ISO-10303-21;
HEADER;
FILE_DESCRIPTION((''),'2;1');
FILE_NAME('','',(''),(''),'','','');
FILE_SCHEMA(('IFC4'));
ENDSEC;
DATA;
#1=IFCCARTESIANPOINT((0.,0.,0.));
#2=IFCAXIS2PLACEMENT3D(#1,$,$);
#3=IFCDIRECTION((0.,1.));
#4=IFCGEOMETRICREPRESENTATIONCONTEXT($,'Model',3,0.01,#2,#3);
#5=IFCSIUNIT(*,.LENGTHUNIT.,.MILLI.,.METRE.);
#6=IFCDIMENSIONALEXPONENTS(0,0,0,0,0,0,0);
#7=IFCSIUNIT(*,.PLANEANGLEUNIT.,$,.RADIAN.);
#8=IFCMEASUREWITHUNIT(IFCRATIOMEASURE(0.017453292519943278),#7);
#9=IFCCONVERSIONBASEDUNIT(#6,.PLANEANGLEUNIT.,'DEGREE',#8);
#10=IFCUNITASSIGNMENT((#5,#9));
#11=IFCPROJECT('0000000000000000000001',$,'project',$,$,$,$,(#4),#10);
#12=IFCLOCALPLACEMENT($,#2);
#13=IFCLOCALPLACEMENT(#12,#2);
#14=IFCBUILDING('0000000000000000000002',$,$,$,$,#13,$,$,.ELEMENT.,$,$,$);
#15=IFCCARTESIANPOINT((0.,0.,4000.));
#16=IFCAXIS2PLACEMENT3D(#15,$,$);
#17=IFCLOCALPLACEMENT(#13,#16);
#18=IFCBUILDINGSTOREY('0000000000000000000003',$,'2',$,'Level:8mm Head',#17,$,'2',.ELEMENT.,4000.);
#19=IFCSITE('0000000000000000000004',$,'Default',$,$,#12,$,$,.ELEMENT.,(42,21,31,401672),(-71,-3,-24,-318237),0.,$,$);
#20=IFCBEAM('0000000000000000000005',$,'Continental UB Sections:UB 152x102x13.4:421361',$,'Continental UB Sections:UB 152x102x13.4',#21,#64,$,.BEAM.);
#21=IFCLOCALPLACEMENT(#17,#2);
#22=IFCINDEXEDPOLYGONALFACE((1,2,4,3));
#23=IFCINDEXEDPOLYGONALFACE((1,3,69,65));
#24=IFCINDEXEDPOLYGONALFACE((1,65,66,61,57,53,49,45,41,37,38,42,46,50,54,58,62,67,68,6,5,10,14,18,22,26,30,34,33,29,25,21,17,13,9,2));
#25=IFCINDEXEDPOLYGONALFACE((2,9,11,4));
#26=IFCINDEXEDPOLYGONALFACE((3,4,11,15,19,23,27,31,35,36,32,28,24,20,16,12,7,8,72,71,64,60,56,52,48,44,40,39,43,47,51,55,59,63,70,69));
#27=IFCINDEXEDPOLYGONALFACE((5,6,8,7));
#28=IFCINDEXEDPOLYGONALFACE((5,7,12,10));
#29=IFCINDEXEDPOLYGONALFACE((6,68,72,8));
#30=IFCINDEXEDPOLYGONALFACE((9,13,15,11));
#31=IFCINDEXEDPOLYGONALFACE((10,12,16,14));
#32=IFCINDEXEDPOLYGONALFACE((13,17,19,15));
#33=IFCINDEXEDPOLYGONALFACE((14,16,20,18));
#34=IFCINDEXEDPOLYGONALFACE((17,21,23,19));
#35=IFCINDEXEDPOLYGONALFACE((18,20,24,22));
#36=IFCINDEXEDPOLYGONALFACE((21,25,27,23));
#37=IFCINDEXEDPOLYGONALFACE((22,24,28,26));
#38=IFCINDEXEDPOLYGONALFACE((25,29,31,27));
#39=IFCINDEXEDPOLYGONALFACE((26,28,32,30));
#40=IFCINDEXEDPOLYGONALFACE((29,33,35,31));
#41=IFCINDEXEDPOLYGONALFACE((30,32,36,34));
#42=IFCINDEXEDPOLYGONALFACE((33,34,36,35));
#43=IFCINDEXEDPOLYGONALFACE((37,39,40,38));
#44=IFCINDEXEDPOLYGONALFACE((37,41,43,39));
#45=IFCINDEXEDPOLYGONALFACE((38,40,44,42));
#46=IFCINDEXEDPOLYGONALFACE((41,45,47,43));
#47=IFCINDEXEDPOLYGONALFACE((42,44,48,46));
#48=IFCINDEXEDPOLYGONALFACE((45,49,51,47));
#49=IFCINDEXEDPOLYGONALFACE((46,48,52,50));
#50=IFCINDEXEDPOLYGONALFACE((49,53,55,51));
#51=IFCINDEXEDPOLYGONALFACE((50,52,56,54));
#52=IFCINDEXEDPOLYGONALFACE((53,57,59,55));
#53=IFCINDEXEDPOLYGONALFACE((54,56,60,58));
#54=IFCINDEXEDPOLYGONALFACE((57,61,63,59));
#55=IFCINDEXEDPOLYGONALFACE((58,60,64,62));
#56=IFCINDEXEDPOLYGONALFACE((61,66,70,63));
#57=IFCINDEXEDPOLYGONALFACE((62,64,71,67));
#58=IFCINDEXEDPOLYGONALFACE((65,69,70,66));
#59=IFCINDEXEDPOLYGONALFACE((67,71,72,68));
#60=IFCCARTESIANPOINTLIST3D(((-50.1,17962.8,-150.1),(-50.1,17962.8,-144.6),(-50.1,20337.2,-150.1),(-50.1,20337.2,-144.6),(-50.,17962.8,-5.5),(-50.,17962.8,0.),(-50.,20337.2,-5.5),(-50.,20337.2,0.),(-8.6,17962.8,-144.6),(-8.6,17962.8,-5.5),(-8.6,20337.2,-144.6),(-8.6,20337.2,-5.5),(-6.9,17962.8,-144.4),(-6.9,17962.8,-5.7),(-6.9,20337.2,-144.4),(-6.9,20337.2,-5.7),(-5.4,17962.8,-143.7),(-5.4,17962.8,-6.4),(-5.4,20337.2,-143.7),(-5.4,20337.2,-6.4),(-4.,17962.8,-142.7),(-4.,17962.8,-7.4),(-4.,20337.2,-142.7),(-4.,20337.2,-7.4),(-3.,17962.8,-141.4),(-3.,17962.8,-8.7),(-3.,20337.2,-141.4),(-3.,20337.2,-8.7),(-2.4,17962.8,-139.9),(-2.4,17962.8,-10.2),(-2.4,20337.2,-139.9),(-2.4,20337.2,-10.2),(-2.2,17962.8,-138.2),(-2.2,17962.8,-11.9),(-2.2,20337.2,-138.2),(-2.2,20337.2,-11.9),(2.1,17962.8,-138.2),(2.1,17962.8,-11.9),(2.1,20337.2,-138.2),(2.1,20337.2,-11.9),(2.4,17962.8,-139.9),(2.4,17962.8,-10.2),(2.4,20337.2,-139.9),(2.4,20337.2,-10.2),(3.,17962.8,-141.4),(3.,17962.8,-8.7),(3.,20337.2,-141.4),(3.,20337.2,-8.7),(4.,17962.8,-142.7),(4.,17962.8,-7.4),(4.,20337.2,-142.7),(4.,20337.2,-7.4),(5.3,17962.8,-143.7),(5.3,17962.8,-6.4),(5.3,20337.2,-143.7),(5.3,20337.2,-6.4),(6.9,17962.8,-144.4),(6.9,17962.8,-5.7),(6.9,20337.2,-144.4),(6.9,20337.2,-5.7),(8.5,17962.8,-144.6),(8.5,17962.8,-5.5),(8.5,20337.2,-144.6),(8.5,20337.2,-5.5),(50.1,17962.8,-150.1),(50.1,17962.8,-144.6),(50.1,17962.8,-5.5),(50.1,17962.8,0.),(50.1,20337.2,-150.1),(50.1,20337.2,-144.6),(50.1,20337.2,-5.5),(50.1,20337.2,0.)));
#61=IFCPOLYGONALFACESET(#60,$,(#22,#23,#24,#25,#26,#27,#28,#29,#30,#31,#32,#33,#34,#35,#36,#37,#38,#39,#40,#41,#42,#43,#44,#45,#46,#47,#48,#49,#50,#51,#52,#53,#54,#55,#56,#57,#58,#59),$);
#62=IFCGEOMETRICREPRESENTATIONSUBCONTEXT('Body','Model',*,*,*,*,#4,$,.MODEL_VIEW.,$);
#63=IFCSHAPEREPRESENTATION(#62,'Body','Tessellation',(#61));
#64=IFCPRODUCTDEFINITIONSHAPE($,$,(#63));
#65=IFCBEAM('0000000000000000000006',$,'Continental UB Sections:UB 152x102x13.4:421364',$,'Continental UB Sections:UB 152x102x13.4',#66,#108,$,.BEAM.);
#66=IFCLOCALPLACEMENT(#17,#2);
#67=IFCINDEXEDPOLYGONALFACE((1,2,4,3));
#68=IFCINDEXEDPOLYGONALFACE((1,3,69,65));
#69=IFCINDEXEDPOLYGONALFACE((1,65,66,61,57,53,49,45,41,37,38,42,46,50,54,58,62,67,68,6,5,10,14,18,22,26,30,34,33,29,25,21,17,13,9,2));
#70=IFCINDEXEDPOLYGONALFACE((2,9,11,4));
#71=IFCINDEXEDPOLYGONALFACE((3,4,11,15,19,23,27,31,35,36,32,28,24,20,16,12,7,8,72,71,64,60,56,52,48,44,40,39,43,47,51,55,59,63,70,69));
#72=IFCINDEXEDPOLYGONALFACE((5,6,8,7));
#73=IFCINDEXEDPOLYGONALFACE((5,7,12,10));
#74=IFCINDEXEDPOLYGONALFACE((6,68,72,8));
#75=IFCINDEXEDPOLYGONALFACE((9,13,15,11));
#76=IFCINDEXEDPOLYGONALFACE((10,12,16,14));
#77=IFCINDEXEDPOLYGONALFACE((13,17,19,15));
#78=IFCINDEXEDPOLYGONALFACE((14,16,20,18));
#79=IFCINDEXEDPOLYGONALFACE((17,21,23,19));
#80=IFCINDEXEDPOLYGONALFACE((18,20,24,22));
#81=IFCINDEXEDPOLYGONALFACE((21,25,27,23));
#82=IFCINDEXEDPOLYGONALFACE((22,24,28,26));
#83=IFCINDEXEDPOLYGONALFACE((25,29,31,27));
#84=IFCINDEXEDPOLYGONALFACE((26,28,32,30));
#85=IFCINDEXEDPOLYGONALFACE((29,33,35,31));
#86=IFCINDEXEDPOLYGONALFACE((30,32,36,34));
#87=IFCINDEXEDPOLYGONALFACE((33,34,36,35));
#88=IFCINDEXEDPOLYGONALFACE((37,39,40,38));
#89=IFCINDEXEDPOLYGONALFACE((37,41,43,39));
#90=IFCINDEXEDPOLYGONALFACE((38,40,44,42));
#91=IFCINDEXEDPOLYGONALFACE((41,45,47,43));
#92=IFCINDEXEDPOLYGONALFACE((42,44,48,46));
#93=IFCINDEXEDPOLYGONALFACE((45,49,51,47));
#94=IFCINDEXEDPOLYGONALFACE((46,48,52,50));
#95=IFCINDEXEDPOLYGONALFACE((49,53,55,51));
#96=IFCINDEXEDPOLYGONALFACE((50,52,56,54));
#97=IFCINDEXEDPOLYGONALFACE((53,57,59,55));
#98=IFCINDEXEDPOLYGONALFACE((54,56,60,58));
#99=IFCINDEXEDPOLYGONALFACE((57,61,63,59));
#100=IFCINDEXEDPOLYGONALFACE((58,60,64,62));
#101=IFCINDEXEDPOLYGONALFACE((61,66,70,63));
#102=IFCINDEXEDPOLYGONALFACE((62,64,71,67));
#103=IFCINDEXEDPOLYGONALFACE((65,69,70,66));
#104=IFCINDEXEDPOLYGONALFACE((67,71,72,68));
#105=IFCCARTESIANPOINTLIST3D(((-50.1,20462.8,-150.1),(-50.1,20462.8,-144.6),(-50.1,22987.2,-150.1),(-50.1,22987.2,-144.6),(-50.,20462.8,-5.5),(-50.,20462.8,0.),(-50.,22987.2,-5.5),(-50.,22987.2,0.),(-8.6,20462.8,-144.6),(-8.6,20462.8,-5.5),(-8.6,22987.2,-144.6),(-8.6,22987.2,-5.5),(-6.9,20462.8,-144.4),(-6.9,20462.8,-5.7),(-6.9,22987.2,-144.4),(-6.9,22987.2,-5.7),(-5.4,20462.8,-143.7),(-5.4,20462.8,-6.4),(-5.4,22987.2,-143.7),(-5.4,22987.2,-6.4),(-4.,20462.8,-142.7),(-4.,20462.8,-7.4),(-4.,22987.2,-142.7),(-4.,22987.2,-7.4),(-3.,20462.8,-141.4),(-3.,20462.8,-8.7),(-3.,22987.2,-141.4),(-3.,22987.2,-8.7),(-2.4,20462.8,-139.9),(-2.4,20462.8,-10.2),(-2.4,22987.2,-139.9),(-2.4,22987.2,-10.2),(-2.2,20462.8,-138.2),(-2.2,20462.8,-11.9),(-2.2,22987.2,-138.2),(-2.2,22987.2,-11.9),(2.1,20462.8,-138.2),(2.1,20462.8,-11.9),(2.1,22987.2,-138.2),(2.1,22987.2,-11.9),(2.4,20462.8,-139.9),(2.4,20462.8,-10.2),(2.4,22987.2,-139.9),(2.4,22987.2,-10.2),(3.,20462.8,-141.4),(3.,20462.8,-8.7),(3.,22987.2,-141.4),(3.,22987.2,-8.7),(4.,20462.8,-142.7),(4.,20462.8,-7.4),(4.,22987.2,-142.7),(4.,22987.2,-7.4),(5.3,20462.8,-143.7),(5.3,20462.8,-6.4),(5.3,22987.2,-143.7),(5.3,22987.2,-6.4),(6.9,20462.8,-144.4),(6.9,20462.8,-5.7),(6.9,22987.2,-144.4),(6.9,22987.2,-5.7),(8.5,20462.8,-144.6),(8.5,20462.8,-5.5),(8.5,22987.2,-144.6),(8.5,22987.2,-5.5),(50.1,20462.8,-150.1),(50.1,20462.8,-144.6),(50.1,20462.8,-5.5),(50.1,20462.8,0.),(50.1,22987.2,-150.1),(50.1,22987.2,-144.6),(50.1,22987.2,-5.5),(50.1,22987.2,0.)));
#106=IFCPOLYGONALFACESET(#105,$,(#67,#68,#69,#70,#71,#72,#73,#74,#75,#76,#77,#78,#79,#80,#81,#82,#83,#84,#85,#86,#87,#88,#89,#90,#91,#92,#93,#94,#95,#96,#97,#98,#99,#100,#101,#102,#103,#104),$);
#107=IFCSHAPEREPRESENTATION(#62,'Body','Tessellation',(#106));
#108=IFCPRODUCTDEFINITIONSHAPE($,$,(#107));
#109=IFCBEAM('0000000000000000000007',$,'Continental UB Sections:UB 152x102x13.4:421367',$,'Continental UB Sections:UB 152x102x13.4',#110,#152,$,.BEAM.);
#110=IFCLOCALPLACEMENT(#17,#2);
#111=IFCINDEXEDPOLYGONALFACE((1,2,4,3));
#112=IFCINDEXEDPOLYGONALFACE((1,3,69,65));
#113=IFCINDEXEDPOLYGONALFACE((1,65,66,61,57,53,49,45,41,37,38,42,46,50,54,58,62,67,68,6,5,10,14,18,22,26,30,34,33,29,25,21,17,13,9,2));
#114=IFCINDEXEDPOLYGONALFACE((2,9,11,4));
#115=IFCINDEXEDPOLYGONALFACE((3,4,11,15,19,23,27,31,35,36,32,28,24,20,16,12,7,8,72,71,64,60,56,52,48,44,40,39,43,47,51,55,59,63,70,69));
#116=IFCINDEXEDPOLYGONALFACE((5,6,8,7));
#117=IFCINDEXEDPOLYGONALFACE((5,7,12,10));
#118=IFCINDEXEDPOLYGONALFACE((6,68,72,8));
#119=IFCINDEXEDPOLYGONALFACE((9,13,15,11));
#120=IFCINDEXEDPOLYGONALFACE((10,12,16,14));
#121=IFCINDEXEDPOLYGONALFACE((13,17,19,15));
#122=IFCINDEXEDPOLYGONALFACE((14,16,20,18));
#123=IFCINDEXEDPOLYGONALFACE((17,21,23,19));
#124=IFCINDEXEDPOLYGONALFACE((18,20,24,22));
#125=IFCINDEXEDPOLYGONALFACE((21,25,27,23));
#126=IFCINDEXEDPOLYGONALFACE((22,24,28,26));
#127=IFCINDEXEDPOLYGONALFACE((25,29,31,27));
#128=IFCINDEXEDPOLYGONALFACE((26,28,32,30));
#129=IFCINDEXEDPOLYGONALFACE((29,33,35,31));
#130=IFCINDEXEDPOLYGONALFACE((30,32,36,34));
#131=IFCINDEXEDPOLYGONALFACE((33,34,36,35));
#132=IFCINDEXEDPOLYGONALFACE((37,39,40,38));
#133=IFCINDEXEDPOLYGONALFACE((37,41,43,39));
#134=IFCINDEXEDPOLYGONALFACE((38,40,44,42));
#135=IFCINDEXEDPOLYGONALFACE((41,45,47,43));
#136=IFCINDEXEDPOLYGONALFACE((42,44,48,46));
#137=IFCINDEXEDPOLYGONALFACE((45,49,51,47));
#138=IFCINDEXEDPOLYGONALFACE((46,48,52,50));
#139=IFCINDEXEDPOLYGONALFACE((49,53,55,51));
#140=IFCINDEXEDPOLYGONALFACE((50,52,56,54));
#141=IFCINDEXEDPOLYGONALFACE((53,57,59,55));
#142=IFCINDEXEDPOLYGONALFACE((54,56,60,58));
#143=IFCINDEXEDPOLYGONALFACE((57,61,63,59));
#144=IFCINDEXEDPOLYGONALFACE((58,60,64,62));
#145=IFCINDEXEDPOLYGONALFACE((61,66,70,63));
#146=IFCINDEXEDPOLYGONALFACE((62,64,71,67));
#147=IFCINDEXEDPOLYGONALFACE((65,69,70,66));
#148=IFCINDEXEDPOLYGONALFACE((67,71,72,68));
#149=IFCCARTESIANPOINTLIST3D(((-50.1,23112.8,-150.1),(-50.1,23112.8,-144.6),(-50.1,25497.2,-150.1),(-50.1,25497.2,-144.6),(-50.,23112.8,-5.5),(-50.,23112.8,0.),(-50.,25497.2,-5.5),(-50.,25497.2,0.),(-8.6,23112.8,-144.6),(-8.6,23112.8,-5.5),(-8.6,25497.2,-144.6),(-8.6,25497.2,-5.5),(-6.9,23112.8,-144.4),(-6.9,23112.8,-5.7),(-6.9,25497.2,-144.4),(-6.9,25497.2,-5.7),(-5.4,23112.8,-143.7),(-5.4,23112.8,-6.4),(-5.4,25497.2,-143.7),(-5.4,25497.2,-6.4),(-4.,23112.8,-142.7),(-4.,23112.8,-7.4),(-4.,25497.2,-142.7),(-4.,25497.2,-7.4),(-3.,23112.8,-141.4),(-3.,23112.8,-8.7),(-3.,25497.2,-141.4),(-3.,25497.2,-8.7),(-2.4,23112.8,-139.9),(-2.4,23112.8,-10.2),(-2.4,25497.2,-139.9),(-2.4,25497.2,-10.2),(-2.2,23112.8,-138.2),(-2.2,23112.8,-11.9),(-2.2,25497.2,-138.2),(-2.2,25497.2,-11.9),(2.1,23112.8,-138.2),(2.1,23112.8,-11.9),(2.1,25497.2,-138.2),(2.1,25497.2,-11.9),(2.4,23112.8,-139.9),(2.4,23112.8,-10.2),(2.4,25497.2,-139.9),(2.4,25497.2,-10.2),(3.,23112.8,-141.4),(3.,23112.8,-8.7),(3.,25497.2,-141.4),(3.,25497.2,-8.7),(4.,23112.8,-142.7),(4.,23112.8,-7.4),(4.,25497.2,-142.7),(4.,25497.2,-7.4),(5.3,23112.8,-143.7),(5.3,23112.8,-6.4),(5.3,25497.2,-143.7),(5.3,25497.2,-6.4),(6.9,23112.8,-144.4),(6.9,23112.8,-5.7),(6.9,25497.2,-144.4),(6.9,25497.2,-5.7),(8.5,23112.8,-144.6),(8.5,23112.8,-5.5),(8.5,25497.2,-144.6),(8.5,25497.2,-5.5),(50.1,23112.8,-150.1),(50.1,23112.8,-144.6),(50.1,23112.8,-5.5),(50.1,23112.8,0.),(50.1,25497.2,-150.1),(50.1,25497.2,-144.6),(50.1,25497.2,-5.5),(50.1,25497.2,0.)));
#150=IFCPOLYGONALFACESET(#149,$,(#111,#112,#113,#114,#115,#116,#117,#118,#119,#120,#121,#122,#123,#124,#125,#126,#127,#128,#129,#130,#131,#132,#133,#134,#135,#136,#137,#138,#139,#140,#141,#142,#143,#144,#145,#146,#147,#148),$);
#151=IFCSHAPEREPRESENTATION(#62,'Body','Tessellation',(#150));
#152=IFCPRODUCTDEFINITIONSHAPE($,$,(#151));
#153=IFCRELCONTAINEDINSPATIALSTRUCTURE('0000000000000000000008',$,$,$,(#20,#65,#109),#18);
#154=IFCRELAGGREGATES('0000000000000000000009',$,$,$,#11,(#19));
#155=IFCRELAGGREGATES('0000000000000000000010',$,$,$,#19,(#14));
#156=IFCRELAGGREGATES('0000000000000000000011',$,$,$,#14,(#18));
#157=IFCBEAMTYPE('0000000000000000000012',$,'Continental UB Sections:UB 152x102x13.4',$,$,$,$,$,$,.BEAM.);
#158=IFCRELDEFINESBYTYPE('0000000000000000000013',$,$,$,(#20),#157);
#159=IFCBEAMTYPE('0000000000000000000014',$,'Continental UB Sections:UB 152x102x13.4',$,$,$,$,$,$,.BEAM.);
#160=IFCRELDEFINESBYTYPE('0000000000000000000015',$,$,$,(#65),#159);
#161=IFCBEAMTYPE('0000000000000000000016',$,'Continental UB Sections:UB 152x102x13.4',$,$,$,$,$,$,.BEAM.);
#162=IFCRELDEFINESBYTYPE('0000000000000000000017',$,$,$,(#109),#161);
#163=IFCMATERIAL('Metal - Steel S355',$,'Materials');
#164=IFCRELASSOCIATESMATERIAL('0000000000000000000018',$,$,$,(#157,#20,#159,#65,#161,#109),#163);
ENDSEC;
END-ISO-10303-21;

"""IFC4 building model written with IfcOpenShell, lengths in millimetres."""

from ifc_helpers import new_model, entity, si_unit, converted_unit, direction, frame, origin, place, context, subcontext, project, spatial, line, arc, indexed_curve, outline, extrude, source, transform, mapped, material, type_object, type_shapes, element, save


model = new_model("IFC4")

# Units and contexts
model_context = context("Model", 3, precision=0.01, world=origin(), true_north=direction((0.0, 1.0)))
body_context = subcontext(model_context, "Body", "Model", "MODEL_VIEW")
ifc_project = project(units=[si_unit("LENGTHUNIT", "METRE", prefix="MILLI"), converted_unit("PLANEANGLEUNIT", "DEGREE", entity("IfcRatioMeasure", 0.017453292519943278), si_unit("PLANEANGLEUNIT", "RADIAN"), dimensions=[0, 0, 0, 0, 0, 0, 0])], contexts=[model_context])

# Site, building, storey
site_placement = place(None, origin())
site = spatial("IfcSite", under=ifc_project, at=site_placement, Name="Default", CompositionType="ELEMENT", RefLatitude=(42, 21, 31, 401672), RefLongitude=(-71, -3, -24, -318237), RefElevation=0.0)
building_placement = place(site_placement, origin())
building = spatial("IfcBuilding", under=site, at=building_placement, CompositionType="ELEMENT")
storey_placement = place(building_placement, frame((0.0, 0.0, 4000.0)))
storey = spatial("IfcBuildingStorey", under=building, at=storey_placement, Name="2", ObjectType="Level:8mm Head", LongName="2", CompositionType="ELEMENT", Elevation=4000.0)

# Beams
ifc_material_1 = material(Name="Metal - Steel S355", Category="Materials")
beam_type_1 = type_object("IfcBeamType", Name="Continental UB Sections:UB 152x102x13.4", PredefinedType="BEAM", material=ifc_material_1)
shared_shape_1 = source(origin(), body_context, "Body", "SweptSolid", [
    extrude(outline(indexed_curve([(-75.0, -50.1), (-69.6, -50.1), (-69.6, -8.5), (-67.7, -4.0), (-63.2, -2.1), (63.1, -2.1), (67.7, -4.0), (69.5, -8.5), (69.5, -50.1), (75.1, -50.1), (75.1, 50.1), (69.5, 50.1), (69.5, 8.6), (67.7, 4.0), (63.1, 2.2), (-63.2, 2.2), (-67.7, 4.0), (-69.6, 8.6), (-69.6, 50.0), (-75.0, 50.0)], segments=[line(1, 2, 3), arc(3, 4, 5), line(5, 6), arc(6, 7, 8), line(8, 9, 10, 11, 12, 13), arc(13, 14, 15), line(15, 16), arc(16, 17, 18), line(18, 19, 20, 1)], self_intersect=False)), frame((-1187.2, 0.0, 0.0), z_axis=(1.0, 0.0, 0.0), x_axis=(0.0, 0.0, -1.0)), (0.0, 0.0, 1.0), 2374.4),
])
type_shapes(beam_type_1, [shared_shape_1])
for number, where, z_axis, x_axis, name in (
    (1, (0.0, 19150.0, -75.1), (0.0, 0.0, 1.0), (0.0, 1.0, 0.0), "Continental UB Sections:UB 152x102x13.4:421361"),
):
    element("IfcBeam", number, at=place(storey_placement, frame(where, z_axis=z_axis, x_axis=x_axis)), inside=storey, type_object=beam_type_1, material=ifc_material_1, Name=name, ObjectType="Continental UB Sections:UB 152x102x13.4", PredefinedType="BEAM", context=body_context, shape_type="MappedRepresentation", body=[
        mapped(shared_shape_1, transform((0.0, 0.0, 0.0), scale=1.0)),
    ])
beam_type_2 = type_object("IfcBeamType", Name="Continental UB Sections:UB 152x102x13.4", PredefinedType="BEAM", material=ifc_material_1)
shared_shape_2 = source(origin(), body_context, "Body", "SweptSolid", [
    extrude(outline(indexed_curve([(-75.0, -50.1), (-69.6, -50.1), (-69.6, -8.5), (-67.7, -4.0), (-63.2, -2.1), (63.1, -2.1), (67.7, -4.0), (69.5, -8.5), (69.5, -50.1), (75.1, -50.1), (75.1, 50.1), (69.5, 50.1), (69.5, 8.6), (67.7, 4.0), (63.1, 2.2), (-63.2, 2.2), (-67.7, 4.0), (-69.6, 8.6), (-69.6, 50.0), (-75.0, 50.0)], segments=[line(1, 2, 3), arc(3, 4, 5), line(5, 6), arc(6, 7, 8), line(8, 9, 10, 11, 12, 13), arc(13, 14, 15), line(15, 16), arc(16, 17, 18), line(18, 19, 20, 1)], self_intersect=False)), frame((-1262.2, 0.0, 0.0), z_axis=(1.0, 0.0, 0.0), x_axis=(0.0, 0.0, -1.0)), (0.0, 0.0, 1.0), 2524.4),
])
type_shapes(beam_type_2, [shared_shape_2])
beam_1_placement = place(storey_placement, frame((0.0, 21725.0, -75.1), z_axis=(0.0, 0.0, 1.0), x_axis=(0.0, 1.0, 0.0)))
element("IfcBeam", 2, at=beam_1_placement, inside=storey, type_object=beam_type_2, material=ifc_material_1, Name="Continental UB Sections:UB 152x102x13.4:421364", ObjectType="Continental UB Sections:UB 152x102x13.4", PredefinedType="BEAM", context=body_context, shape_type="MappedRepresentation", body=[
    mapped(shared_shape_2, transform((0.0, 0.0, 0.0), scale=1.0)),
])
beam_type_3 = type_object("IfcBeamType", Name="Continental UB Sections:UB 152x102x13.4", PredefinedType="BEAM", material=ifc_material_1)
shared_shape_3 = source(origin(), body_context, "Body", "SweptSolid", [
    extrude(outline(indexed_curve([(-75.0, -50.1), (-69.6, -50.1), (-69.6, -8.5), (-67.7, -4.0), (-63.2, -2.1), (63.1, -2.1), (67.7, -4.0), (69.5, -8.5), (69.5, -50.1), (75.1, -50.1), (75.1, 50.1), (69.5, 50.1), (69.5, 8.6), (67.7, 4.0), (63.1, 2.2), (-63.2, 2.2), (-67.7, 4.0), (-69.6, 8.6), (-69.6, 50.0), (-75.0, 50.0)], segments=[line(1, 2, 3), arc(3, 4, 5), line(5, 6), arc(6, 7, 8), line(8, 9, 10, 11, 12, 13), arc(13, 14, 15), line(15, 16), arc(16, 17, 18), line(18, 19, 20, 1)], self_intersect=False)), frame((-1192.2, 0.0, 0.0), z_axis=(1.0, 0.0, 0.0), x_axis=(0.0, 0.0, -1.0)), (0.0, 0.0, 1.0), 2384.4),
])
type_shapes(beam_type_3, [shared_shape_3])
beam_2_placement = place(storey_placement, frame((0.0, 24305.0, -75.1), z_axis=(0.0, 0.0, 1.0), x_axis=(0.0, 1.0, 0.0)))
element("IfcBeam", 3, at=beam_2_placement, inside=storey, type_object=beam_type_3, material=ifc_material_1, Name="Continental UB Sections:UB 152x102x13.4:421367", ObjectType="Continental UB Sections:UB 152x102x13.4", PredefinedType="BEAM", context=body_context, shape_type="MappedRepresentation", body=[
    mapped(shared_shape_3, transform((0.0, 0.0, 0.0), scale=1.0)),
])

save(model, "model.ifc")
